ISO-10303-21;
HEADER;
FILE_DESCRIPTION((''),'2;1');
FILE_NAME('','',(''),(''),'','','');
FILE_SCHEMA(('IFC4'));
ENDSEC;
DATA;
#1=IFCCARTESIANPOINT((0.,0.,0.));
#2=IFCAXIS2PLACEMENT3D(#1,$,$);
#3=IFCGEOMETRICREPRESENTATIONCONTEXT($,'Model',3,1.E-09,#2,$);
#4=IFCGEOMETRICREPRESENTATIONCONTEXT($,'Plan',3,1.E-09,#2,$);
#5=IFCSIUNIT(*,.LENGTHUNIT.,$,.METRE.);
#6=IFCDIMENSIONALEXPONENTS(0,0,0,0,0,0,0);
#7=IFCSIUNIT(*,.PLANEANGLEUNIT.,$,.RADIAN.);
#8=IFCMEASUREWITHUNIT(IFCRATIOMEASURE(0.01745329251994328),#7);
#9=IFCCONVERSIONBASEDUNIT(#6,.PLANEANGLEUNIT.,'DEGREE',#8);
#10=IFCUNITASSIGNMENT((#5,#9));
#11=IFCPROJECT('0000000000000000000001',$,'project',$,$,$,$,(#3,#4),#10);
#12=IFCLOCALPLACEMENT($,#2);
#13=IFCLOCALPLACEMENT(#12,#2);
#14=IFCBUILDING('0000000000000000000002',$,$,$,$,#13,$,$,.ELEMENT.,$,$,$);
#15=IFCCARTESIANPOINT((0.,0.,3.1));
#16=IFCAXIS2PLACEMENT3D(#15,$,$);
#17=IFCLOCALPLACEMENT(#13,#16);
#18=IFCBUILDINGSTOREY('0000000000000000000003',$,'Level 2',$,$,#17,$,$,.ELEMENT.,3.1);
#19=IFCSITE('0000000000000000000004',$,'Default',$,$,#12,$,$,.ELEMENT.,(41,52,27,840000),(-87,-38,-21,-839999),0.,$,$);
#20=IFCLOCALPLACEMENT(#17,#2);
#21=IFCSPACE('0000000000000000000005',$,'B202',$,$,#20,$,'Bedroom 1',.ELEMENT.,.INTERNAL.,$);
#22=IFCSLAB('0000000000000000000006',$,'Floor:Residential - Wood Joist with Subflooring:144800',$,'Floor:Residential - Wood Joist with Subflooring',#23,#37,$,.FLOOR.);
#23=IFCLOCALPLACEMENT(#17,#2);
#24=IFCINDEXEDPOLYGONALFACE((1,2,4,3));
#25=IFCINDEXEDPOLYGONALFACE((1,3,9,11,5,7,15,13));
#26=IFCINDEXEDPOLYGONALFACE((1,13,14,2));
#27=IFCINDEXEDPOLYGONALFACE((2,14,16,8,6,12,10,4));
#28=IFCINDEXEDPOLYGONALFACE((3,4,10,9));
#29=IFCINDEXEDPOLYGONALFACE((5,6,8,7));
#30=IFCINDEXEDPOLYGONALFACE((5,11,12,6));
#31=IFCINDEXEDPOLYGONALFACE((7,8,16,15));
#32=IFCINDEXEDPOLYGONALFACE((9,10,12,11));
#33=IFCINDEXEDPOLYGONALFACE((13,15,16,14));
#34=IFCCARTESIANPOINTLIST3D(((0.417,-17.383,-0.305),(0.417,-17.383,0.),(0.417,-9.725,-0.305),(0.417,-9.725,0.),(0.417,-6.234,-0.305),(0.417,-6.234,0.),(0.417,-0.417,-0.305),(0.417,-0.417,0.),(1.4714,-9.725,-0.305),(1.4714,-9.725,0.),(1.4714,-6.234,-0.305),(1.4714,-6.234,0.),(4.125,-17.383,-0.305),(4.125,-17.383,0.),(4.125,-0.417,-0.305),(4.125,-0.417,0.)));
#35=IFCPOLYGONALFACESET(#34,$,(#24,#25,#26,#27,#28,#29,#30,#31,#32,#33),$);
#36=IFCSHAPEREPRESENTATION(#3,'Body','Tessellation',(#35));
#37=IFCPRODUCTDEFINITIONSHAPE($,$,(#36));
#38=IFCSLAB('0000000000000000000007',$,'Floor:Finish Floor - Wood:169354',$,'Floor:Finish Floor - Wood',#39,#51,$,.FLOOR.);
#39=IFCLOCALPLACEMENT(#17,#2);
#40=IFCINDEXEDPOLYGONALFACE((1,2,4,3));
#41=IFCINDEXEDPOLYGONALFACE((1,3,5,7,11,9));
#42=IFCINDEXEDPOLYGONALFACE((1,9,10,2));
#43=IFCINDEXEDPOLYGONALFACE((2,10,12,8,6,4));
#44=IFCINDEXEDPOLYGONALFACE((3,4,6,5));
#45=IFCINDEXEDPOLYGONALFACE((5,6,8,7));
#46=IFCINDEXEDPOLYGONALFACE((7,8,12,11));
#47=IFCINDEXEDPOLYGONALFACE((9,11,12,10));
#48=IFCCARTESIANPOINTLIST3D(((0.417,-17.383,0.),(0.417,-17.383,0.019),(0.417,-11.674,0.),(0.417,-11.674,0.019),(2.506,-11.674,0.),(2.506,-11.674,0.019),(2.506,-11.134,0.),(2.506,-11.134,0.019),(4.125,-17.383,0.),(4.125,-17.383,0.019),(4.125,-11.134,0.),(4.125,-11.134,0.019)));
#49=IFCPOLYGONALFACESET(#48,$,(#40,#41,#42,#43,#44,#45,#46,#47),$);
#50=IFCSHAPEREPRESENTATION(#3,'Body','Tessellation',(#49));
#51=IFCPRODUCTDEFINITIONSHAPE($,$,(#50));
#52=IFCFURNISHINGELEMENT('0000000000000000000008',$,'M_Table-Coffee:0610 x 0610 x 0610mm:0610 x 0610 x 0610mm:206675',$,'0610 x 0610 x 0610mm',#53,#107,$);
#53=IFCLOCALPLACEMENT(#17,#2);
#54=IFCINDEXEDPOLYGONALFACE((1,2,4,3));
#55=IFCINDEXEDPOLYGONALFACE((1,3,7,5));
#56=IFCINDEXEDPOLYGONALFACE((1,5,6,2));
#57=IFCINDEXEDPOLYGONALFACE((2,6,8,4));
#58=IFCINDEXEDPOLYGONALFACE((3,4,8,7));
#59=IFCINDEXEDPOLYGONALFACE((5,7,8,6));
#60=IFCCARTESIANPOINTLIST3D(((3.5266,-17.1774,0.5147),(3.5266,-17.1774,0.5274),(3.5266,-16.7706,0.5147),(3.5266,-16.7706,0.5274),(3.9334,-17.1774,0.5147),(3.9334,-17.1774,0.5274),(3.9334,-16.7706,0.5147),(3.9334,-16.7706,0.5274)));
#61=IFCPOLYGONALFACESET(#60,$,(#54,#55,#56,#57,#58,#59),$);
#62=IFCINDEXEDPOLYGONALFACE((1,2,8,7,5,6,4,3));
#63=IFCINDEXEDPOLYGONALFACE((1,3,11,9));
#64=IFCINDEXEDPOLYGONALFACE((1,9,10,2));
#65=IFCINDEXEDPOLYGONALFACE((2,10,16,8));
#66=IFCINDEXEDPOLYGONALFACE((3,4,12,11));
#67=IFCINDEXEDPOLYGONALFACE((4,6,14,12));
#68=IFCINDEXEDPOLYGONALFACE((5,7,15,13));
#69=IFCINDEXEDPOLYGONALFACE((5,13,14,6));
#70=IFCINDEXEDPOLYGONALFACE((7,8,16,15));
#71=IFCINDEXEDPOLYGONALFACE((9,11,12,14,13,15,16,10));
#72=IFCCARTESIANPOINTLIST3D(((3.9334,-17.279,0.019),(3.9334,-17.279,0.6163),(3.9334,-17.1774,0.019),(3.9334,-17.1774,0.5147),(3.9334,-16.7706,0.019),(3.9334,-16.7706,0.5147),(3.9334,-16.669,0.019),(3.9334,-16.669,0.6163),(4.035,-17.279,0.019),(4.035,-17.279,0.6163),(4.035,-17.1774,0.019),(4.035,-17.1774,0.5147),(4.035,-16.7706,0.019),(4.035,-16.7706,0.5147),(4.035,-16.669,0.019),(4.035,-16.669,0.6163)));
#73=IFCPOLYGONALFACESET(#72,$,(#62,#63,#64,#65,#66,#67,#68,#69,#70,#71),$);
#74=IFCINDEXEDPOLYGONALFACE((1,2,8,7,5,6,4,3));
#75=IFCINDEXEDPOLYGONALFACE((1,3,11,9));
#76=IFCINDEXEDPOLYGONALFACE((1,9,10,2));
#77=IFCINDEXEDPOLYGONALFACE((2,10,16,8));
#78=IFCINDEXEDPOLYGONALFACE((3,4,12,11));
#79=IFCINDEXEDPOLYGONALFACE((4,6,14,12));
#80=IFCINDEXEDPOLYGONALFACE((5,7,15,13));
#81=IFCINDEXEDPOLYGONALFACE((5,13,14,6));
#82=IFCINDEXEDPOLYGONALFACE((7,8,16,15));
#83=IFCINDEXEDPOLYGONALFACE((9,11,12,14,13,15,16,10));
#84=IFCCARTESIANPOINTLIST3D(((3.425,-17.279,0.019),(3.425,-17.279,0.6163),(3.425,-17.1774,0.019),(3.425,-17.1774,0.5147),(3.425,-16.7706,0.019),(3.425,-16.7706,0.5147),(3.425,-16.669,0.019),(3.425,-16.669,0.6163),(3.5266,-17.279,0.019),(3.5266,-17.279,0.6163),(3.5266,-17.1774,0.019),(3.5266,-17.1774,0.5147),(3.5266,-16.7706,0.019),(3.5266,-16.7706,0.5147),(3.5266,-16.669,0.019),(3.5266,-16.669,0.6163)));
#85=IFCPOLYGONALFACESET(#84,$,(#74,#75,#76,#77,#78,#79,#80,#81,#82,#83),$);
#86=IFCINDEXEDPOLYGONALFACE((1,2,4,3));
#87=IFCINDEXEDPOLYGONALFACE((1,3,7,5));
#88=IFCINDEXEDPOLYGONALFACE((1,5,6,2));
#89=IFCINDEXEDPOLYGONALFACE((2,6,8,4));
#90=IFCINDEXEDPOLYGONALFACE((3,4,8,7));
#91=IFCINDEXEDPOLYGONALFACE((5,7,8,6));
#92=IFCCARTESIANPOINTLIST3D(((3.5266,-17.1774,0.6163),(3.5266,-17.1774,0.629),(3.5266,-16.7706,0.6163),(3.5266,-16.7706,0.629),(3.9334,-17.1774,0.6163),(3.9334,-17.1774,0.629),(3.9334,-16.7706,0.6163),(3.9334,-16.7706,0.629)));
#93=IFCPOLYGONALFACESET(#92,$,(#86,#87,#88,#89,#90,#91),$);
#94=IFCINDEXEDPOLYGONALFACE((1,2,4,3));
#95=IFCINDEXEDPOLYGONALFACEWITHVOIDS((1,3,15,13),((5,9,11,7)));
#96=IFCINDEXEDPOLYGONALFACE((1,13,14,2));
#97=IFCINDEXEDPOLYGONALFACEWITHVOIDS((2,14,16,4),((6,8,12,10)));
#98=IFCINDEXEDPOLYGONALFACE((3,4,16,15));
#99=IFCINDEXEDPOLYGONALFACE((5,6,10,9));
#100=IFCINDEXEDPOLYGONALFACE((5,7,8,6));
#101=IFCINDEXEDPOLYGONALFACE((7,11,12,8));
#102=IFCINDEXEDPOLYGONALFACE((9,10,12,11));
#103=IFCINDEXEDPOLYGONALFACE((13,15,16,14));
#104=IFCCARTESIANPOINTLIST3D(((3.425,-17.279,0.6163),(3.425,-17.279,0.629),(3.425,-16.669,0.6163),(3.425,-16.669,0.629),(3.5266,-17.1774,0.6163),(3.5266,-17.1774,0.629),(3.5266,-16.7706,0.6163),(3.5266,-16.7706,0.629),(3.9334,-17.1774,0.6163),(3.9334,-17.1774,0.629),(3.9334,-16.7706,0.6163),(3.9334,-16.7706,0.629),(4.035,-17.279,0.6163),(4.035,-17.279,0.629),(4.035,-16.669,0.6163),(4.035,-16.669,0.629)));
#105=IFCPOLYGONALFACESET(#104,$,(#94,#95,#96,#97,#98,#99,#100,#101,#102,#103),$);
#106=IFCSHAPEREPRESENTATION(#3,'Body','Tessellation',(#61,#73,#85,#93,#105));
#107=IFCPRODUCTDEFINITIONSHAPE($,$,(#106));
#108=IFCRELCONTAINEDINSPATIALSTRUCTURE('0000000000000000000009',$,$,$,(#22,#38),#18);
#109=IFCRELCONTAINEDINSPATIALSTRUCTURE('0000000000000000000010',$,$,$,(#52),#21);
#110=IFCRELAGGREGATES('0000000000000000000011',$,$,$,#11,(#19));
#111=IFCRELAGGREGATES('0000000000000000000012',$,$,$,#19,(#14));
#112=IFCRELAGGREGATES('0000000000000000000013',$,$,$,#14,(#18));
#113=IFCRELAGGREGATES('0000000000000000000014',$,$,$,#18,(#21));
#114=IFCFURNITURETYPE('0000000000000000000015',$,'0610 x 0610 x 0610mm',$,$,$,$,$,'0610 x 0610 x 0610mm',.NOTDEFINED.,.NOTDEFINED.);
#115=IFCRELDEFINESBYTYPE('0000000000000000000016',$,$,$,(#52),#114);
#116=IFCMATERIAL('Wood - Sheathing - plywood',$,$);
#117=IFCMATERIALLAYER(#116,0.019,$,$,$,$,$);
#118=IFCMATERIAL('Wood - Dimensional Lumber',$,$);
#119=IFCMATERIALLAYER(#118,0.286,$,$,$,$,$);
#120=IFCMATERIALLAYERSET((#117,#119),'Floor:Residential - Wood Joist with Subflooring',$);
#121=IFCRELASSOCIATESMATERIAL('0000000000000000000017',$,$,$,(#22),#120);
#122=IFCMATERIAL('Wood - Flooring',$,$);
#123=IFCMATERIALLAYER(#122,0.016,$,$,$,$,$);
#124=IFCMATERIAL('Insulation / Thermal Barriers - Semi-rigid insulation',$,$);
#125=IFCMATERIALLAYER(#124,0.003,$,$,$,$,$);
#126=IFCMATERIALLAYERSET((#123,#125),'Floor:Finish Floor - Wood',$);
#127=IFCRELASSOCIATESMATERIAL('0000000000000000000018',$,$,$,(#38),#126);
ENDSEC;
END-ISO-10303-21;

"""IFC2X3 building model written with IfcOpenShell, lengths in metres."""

from ifc_helpers import new_model, entity, si_unit, converted_unit, frame, origin, origin_2d_with_axis, place, context, project, spatial, polyline, rectangle, outline, extrude, source, transform, mapped, material, layer, layer_set, layer_usage, type_object, type_shapes, element, save


model = new_model("IFC2X3")

# Units and contexts
model_context = context("Model", 3, precision=1e-09, world=origin())
plan_context = context("Plan", 3, precision=1e-09, world=origin())
ifc_project = project(units=[si_unit("LENGTHUNIT", "METRE"), converted_unit("PLANEANGLEUNIT", "DEGREE", entity("IfcRatioMeasure", 0.01745329251994328), si_unit("PLANEANGLEUNIT", "RADIAN"), dimensions=[0, 0, 0, 0, 0, 0, 0])], contexts=[model_context, plan_context])

# Site, building, storey
site_placement = place(None, origin())
site = spatial("IfcSite", under=ifc_project, at=site_placement, Name="Default", CompositionType="ELEMENT", RefLatitude=(41, 52, 27, 840000), RefLongitude=(-87, -38, -21, -839999), RefElevation=0.0)
building_placement = place(site_placement, origin())
building = spatial("IfcBuilding", under=site, at=building_placement, CompositionType="ELEMENT")
storey_placement = place(building_placement, frame((0.0, 0.0, 3.1)))
storey = spatial("IfcBuildingStorey", under=building, at=storey_placement, Name="Level 2", CompositionType="ELEMENT", Elevation=3.1)

# Slabs
ifc_material_1 = material(Name="Wood - Sheathing - plywood")
ifc_layer_1 = layer(ifc_material_1, 0.019)
ifc_material_2 = material(Name="Wood - Dimensional Lumber")
ifc_layer_2 = layer(ifc_material_2, 0.286)
ifc_layer_set_1 = layer_set([ifc_layer_1, ifc_layer_2], Name="Floor:Residential - Wood Joist with Subflooring")
ifc_layer_usage_1 = layer_usage(ifc_layer_set_1, "AXIS3", "POSITIVE", 0.0)
slab_1_placement = place(storey_placement, frame((0.417, -17.383, -0.305)))
element("IfcSlab", 1, at=slab_1_placement, inside=storey, material=ifc_layer_usage_1, Name="Floor:Residential - Wood Joist with Subflooring:144800", ObjectType="Floor:Residential - Wood Joist with Subflooring", PredefinedType="FLOOR", context=model_context, shape_type="SweptSolid", body=[
    extrude(outline(polyline([(-1.854, 8.483), (-1.854, -8.483), (1.854, -8.483), (1.854, -0.825), (0.7996, -0.825), (0.7996, 2.666), (1.854, 2.666), (1.854, 8.483), (-1.854, 8.483)])), frame((1.854, 8.483, 0.305), z_axis=(0.0, 0.0, -1.0), x_axis=(-1.0, 0.0, 0.0)), (0.0, 0.0, 1.0), 0.305),
])
ifc_material_3 = material(Name="Wood - Flooring")
ifc_layer_3 = layer(ifc_material_3, 0.016)
ifc_material_4 = material(Name="Insulation / Thermal Barriers - Semi-rigid insulation")
ifc_layer_4 = layer(ifc_material_4, 0.003)
ifc_layer_set_2 = layer_set([ifc_layer_3, ifc_layer_4], Name="Floor:Finish Floor - Wood")
ifc_layer_usage_2 = layer_usage(ifc_layer_set_2, "AXIS3", "POSITIVE", 0.0)
slab_2_placement = place(storey_placement, frame((0.417, -17.383, 0.0)))
element("IfcSlab", 2, at=slab_2_placement, inside=storey, material=ifc_layer_usage_2, Name="Floor:Finish Floor - Wood:169354", ObjectType="Floor:Finish Floor - Wood", PredefinedType="FLOOR", context=model_context, shape_type="SweptSolid", body=[
    extrude(outline(polyline([(-1.854, -3.1245), (1.854, -3.1245), (1.854, 2.5845), (-0.235, 2.5845), (-0.235, 3.1245), (-1.854, 3.1245), (-1.854, -3.1245)])), frame((1.854, 3.1245, 0.019), z_axis=(0.0, 0.0, -1.0), x_axis=(-1.0, 0.0, 0.0)), (0.0, 0.0, 1.0), 0.019),
])

# Shared definitions
space_placement = place(storey_placement, origin())
space = spatial("IfcSpace", under=storey, at=space_placement, Name="B202", LongName="Bedroom 1", CompositionType="ELEMENT", InteriorOrExteriorSpace="INTERNAL")

# Furnishing element
furniture_type = type_object("IfcFurnitureType", Name="0610 x 0610 x 0610mm", ElementType="0610 x 0610 x 0610mm", AssemblyPlace="NOTDEFINED")
shared_shape_1 = source(origin(), model_context, "Body", "SweptSolid", [
    extrude(rectangle(XDim=0.4068, YDim=0.4068, at=origin_2d_with_axis()), frame((0.0183, 0.0952, 0.4957), z_axis=(0.0, 0.0, 1.0), x_axis=(-1.0, 0.0, 0.0)), (0.0, 0.0, 1.0), 0.0127),
    extrude(outline(polyline([(-0.2732, -0.305), (0.324, -0.305), (0.324, 0.305), (-0.2732, 0.305), (-0.2732, 0.2034), (0.2225, 0.2034), (0.2225, -0.2034), (-0.2732, -0.2034), (-0.2732, -0.305)])), frame((0.2217, 0.0952, 0.2732), z_axis=(1.0, 0.0, 0.0), x_axis=(0.0, 0.0, 1.0)), (0.0, 0.0, 1.0), 0.1016),
    extrude(outline(polyline([(-0.305, -0.3241), (0.305, -0.3241), (0.305, 0.2733), (0.2034, 0.2733), (0.2034, -0.2224), (-0.2034, -0.2224), (-0.2034, 0.2733), (-0.305, 0.2733), (-0.305, -0.3241)])), frame((-0.2867, 0.0952, 0.2733), z_axis=(1.0, 0.0, 0.0), x_axis=(0.0, -1.0, 0.0)), (0.0, 0.0, 1.0), 0.1016),
    extrude(rectangle(XDim=0.4068, YDim=0.4068, at=origin_2d_with_axis()), frame((0.0183, 0.0952, 0.5973), z_axis=(0.0, 0.0, 1.0), x_axis=(-1.0, 0.0, 0.0)), (0.0, 0.0, 1.0), 0.0127),
    extrude(outline(polyline([(-0.305, -0.305), (0.305, -0.305), (0.305, 0.305), (-0.305, 0.305), (-0.305, -0.305)]), holes=[polyline([(-0.2034, -0.2034), (-0.2034, 0.2034), (0.2034, 0.2034), (0.2034, -0.2034), (-0.2034, -0.2034)])]), frame((0.0183, 0.0952, 0.5973), z_axis=(0.0, 0.0, 1.0), x_axis=(-1.0, 0.0, 0.0)), (0.0, 0.0, 1.0), 0.0127),
])
type_shapes(furniture_type, [shared_shape_1])
furnishing_placement = place(space_placement, frame((3.7117, -17.0692, 0.019)))
element("IfcFurnishingElement", 3, at=furnishing_placement, inside=space, type_object=furniture_type, Name="M_Table-Coffee:0610 x 0610 x 0610mm:0610 x 0610 x 0610mm:206675", ObjectType="0610 x 0610 x 0610mm", context=model_context, shape_type="MappedRepresentation", body=[
    mapped(shared_shape_1, transform((0.0, 0.0, 0.0), scale=1.0)),
])

save(model, "model.ifc")
